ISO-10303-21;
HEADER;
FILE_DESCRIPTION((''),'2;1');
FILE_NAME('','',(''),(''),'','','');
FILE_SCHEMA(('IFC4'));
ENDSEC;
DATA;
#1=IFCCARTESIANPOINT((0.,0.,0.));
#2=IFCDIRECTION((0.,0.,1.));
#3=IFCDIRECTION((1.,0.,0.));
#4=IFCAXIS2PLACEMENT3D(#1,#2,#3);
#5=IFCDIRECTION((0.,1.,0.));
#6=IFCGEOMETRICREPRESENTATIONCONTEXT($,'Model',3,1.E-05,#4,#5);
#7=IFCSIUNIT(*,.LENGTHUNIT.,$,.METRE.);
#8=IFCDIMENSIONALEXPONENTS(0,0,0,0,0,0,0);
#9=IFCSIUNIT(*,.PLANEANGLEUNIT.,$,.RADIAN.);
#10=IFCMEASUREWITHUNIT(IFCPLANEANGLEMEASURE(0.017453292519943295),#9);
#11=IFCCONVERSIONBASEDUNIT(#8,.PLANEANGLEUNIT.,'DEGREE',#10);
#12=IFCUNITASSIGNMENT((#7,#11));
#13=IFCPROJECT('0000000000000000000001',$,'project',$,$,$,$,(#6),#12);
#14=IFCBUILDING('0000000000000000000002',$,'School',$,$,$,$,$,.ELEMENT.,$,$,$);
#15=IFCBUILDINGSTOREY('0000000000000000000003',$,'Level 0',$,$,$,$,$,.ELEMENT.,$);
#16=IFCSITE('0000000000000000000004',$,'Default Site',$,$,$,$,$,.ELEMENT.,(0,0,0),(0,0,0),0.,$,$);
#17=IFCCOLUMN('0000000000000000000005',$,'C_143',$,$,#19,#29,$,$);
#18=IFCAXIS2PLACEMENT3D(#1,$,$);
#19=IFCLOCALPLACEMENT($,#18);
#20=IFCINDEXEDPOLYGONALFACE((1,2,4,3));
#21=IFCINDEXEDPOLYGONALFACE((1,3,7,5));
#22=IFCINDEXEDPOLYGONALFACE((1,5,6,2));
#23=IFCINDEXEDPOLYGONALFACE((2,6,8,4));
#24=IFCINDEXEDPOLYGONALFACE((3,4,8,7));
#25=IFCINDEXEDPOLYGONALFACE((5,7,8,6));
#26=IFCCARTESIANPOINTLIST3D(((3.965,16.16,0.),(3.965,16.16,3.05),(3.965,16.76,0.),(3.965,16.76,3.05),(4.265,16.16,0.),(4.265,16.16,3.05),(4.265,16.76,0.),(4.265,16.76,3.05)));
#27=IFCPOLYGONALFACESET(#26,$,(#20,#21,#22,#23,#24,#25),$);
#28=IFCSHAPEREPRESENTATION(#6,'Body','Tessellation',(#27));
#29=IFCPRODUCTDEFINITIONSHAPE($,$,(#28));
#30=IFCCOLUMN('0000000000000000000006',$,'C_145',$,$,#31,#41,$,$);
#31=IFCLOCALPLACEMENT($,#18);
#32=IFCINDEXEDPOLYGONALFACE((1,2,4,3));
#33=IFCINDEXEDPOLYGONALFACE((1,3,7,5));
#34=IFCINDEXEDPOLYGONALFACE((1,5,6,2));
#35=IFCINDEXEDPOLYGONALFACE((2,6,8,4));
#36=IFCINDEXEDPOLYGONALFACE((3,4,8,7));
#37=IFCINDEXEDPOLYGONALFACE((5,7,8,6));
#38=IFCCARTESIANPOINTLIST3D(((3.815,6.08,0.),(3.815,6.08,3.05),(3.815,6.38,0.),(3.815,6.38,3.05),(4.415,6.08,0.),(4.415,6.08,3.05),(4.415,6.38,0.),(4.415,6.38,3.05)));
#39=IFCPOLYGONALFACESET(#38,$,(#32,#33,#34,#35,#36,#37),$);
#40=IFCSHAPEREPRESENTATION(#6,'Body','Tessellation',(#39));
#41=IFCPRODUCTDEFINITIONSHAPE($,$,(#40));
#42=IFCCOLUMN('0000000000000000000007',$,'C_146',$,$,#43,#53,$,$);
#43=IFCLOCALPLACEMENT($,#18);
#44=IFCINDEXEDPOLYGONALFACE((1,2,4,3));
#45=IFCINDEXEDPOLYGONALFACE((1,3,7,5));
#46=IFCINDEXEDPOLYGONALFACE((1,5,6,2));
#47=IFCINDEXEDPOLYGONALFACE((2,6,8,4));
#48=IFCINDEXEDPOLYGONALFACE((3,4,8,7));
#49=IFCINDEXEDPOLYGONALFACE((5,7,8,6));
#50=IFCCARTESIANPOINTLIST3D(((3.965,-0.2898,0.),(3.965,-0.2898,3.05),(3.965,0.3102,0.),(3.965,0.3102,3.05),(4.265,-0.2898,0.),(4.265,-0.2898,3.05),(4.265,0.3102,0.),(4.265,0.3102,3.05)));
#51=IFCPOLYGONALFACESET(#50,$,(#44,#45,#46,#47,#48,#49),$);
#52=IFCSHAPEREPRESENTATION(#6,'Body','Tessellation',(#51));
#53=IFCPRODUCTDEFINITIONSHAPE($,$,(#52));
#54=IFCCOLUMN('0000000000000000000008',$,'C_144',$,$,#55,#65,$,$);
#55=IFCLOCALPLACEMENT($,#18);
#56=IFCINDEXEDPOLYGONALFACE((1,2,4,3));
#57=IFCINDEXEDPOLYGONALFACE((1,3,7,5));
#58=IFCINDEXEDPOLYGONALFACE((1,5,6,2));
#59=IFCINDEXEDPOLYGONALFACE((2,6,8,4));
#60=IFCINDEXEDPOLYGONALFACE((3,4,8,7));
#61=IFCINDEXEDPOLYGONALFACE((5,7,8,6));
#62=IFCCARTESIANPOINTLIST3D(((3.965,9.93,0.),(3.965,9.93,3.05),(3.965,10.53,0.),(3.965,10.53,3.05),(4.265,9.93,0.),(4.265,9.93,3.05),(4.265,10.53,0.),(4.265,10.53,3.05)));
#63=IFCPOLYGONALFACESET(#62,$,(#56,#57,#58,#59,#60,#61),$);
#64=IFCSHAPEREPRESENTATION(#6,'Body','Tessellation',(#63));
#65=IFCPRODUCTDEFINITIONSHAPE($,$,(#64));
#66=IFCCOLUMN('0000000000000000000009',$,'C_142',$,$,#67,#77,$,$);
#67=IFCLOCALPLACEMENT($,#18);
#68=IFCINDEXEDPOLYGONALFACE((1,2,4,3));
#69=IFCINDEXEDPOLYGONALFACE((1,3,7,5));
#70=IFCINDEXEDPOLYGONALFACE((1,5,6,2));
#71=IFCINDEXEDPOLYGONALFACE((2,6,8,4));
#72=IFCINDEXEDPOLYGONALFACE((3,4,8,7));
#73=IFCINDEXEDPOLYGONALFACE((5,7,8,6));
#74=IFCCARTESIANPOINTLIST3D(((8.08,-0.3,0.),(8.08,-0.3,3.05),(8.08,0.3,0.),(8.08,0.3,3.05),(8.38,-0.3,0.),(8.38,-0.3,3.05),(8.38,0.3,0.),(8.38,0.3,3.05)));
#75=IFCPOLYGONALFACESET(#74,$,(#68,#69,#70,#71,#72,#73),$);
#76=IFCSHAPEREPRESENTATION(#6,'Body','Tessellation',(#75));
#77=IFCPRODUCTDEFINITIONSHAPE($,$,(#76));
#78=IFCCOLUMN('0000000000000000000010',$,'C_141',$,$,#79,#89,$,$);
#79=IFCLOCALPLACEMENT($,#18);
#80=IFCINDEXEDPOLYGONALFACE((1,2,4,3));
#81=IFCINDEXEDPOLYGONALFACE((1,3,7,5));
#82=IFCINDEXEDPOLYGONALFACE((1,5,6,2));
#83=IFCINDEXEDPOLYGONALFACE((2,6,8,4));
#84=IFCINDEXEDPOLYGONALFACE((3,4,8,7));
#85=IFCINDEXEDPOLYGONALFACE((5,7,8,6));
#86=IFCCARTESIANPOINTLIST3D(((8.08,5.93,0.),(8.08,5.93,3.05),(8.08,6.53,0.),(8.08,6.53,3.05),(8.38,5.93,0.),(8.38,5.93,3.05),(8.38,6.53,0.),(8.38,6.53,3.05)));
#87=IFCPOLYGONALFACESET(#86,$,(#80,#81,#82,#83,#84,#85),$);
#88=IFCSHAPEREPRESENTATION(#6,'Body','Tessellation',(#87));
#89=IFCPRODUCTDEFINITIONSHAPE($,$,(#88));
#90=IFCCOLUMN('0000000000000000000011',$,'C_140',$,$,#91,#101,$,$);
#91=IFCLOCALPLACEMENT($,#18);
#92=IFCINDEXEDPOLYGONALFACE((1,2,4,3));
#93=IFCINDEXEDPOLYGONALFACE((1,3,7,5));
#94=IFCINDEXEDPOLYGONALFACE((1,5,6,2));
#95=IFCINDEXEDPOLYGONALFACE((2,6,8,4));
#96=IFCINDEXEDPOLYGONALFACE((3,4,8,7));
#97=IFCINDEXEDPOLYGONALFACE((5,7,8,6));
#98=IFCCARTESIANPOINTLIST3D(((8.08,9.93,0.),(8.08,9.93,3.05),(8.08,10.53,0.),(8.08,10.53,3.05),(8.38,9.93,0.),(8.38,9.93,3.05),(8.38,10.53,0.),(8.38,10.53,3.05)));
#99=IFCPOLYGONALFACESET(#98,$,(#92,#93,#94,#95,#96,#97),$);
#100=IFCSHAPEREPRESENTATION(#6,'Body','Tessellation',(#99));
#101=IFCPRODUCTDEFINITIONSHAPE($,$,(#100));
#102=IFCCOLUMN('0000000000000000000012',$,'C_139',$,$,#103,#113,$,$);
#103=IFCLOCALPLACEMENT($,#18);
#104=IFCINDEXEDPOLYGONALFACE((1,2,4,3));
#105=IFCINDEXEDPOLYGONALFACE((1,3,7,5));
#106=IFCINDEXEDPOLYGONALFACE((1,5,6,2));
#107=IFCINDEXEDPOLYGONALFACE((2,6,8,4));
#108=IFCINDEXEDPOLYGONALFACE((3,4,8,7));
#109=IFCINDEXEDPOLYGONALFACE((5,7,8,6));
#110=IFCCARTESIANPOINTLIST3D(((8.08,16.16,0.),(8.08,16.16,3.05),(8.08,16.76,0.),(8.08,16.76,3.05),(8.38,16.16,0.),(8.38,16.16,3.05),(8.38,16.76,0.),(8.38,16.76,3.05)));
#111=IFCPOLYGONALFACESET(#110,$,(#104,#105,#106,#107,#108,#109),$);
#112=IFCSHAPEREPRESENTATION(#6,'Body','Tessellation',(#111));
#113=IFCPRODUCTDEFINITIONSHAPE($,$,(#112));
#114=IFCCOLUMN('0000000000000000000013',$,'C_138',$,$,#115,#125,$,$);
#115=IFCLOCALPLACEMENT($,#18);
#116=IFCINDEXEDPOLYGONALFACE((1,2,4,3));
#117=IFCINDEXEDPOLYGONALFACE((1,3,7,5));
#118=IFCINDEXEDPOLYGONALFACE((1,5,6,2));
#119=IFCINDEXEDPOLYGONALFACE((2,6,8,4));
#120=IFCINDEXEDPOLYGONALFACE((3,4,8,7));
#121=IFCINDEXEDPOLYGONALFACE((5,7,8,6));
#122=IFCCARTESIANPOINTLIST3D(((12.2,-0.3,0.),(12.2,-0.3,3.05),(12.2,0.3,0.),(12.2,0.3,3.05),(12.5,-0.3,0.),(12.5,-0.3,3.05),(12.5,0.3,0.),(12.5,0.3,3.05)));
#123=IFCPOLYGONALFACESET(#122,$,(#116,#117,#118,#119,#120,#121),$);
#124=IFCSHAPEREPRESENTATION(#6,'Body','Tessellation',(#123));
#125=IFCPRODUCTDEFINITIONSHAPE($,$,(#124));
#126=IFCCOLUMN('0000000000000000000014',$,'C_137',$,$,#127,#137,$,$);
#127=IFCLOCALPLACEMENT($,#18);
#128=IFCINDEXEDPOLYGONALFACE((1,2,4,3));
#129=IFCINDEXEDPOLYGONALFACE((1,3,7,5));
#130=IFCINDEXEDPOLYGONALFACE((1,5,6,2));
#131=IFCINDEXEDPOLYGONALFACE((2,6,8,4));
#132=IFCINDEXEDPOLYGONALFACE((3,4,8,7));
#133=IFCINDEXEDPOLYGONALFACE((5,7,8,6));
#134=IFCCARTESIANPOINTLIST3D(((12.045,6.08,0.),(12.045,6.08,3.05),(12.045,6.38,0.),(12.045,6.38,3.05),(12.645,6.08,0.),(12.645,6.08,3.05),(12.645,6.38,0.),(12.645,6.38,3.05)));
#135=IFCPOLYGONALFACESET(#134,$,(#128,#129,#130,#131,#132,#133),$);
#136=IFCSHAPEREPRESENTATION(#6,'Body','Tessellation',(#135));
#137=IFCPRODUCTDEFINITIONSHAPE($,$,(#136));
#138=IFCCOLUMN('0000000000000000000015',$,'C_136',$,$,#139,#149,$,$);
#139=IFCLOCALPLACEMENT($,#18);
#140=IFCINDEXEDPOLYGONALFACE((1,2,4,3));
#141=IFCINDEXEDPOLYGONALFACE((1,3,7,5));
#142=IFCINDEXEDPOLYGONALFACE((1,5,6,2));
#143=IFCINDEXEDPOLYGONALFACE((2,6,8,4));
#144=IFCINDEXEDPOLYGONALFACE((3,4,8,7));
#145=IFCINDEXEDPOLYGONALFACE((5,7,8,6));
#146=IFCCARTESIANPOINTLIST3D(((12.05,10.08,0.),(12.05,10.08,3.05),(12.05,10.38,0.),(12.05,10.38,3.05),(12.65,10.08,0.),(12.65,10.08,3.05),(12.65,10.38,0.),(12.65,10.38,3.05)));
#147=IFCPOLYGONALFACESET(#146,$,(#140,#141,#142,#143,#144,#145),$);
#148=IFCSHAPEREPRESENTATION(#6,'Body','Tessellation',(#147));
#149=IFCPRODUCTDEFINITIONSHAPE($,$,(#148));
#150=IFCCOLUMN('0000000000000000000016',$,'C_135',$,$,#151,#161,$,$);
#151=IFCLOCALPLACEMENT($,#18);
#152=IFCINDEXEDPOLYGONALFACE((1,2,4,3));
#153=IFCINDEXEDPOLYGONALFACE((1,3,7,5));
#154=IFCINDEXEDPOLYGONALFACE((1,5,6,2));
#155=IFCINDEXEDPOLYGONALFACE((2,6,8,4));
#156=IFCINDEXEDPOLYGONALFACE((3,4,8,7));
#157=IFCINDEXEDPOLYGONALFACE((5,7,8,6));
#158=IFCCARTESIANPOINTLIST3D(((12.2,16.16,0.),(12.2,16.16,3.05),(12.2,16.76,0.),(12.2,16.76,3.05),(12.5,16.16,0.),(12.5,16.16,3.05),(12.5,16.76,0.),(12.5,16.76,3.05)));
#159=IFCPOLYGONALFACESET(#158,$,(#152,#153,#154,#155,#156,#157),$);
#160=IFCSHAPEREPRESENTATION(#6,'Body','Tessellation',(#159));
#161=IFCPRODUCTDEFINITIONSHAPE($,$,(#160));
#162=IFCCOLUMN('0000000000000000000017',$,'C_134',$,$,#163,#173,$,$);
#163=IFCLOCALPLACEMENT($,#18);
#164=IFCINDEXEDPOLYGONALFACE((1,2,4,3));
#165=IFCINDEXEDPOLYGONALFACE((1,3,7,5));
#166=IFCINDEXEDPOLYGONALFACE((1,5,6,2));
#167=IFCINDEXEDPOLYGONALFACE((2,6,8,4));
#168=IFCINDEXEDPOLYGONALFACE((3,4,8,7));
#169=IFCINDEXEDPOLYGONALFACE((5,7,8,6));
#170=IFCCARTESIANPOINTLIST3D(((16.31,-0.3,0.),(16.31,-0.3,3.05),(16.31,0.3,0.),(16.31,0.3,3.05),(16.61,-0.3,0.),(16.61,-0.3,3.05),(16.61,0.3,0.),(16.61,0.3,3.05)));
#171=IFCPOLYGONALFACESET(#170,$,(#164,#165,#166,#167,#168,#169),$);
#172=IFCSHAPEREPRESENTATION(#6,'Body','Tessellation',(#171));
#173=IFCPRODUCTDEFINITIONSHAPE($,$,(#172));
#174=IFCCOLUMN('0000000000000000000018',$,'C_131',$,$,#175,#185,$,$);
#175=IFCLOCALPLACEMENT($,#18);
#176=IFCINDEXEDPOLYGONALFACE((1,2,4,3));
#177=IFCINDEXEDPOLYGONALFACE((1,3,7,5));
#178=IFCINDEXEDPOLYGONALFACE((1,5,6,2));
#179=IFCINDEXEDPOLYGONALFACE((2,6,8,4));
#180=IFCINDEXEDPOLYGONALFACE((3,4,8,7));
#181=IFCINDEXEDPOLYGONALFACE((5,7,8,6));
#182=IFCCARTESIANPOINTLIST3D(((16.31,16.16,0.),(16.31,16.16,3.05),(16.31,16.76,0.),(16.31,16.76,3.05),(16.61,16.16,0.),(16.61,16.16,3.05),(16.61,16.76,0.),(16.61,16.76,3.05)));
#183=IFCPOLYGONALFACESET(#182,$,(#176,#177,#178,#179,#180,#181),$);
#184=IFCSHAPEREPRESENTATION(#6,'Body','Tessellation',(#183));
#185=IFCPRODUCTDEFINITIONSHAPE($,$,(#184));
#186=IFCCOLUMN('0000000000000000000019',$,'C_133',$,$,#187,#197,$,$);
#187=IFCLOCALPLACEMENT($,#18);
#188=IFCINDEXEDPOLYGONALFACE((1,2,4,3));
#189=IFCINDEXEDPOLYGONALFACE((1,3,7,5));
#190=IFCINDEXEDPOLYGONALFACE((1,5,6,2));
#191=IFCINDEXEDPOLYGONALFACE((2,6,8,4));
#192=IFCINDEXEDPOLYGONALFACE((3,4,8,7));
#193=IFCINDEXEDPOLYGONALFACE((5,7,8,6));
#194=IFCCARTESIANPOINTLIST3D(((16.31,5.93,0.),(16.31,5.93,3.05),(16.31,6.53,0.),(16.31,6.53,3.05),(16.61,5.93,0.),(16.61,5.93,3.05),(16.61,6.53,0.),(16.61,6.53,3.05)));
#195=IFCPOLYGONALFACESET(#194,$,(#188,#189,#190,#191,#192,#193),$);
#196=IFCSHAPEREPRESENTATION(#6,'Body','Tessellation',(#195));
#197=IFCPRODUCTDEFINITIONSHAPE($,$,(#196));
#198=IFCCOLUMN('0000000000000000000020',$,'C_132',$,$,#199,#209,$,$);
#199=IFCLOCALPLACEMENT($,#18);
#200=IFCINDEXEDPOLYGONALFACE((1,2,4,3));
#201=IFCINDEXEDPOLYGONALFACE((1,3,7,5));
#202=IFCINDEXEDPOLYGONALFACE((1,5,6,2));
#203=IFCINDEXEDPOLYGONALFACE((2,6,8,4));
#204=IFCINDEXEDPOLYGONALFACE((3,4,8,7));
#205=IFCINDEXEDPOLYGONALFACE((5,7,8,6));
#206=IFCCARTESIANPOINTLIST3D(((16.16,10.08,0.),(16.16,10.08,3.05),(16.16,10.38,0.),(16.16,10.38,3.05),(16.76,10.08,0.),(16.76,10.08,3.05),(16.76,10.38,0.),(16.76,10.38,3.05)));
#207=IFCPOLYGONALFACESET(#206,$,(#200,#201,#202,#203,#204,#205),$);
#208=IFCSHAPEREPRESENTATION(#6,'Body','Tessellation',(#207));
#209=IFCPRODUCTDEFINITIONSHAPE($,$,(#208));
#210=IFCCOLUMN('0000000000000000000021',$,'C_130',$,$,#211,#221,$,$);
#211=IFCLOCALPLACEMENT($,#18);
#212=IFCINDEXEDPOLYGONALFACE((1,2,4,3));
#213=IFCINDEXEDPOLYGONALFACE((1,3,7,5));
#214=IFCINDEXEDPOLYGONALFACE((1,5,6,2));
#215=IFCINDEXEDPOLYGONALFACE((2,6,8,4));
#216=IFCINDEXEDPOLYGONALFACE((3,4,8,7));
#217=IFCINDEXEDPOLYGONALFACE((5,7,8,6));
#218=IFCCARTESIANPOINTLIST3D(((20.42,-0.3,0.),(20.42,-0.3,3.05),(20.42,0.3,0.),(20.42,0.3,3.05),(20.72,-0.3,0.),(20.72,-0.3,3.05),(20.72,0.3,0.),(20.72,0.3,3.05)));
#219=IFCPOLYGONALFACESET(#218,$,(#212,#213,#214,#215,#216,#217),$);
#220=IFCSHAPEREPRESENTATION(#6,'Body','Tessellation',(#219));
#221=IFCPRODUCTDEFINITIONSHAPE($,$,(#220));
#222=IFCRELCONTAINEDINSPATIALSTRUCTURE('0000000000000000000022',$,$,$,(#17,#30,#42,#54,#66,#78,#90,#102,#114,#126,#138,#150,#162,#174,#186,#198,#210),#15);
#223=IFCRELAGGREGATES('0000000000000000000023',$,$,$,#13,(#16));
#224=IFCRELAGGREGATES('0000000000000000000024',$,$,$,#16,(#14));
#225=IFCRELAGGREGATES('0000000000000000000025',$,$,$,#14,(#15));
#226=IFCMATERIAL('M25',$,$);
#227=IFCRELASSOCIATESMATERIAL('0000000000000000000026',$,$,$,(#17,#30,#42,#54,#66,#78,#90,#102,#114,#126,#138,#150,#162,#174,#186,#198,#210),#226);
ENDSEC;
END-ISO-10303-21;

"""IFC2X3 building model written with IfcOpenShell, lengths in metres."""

from ifc_helpers import new_model, entity, si_unit, converted_unit, direction, frame, frame_2d, origin_with_axes, place, context, project, spatial, rectangle, extrude, material, element, save


model = new_model("IFC2X3")

# Units and contexts
model_context = context("Model", 3, precision=1e-05, world=origin_with_axes(), true_north=direction((0.0, 1.0, 0.0)))
ifc_project = project(units=[si_unit("LENGTHUNIT", "METRE"), converted_unit("PLANEANGLEUNIT", "DEGREE", entity("IfcPlaneAngleMeasure", 0.017453292519943295), si_unit("PLANEANGLEUNIT", "RADIAN"), dimensions=[0, 0, 0, 0, 0, 0, 0])], contexts=[model_context])

# Site, building, storey
site = spatial("IfcSite", under=ifc_project, Name="Default Site", CompositionType="ELEMENT", RefLatitude=(0, 0, 0), RefLongitude=(0, 0, 0), RefElevation=0.0)
building = spatial("IfcBuilding", under=site, Name="School", CompositionType="ELEMENT")
storey = spatial("IfcBuildingStorey", under=building, Name="Level 0", CompositionType="ELEMENT")

# Columns
ifc_material = material(Name="M25")
placement = place(None, origin_with_axes())
element("IfcColumn", 1, at=placement, inside=storey, material=ifc_material, Name="C_143", context=model_context, shape_type="SweptSolid", body=[
    extrude(rectangle(XDim=0.3, YDim=0.6, at=frame_2d((0.0, 0.0), x_axis=(1.0, 0.0, 0.0))), frame((4.115, 16.46, 0.0), z_axis=(0.0, 0.0, 1.0), x_axis=(1.0, 0.0, 0.0)), (0.0, 0.0, 1.0), 3.05),
])
element("IfcColumn", 2, at=placement, inside=storey, material=ifc_material, Name="C_145", context=model_context, shape_type="SweptSolid", body=[
    extrude(rectangle(XDim=0.6, YDim=0.3, at=frame_2d((0.0, 0.0), x_axis=(1.0, 0.0, 0.0))), frame((4.115, 6.23, 0.0), z_axis=(0.0, 0.0, 1.0), x_axis=(1.0, 0.0, 0.0)), (0.0, 0.0, 1.0), 3.05),
])
element("IfcColumn", 3, at=placement, inside=storey, material=ifc_material, Name="C_146", context=model_context, shape_type="SweptSolid", body=[
    extrude(rectangle(XDim=0.3, YDim=0.6, at=frame_2d((0.0, 0.0), x_axis=(1.0, 0.0, 0.0))), frame((4.115, 0.0102, 0.0), z_axis=(0.0, 0.0, 1.0), x_axis=(1.0, 0.0, 0.0)), (0.0, 0.0, 1.0), 3.05),
])
element("IfcColumn", 4, at=placement, inside=storey, material=ifc_material, Name="C_144", context=model_context, shape_type="SweptSolid", body=[
    extrude(rectangle(XDim=0.3, YDim=0.6, at=frame_2d((0.0, 0.0), x_axis=(1.0, 0.0, 0.0))), frame((4.115, 10.23, 0.0), z_axis=(0.0, 0.0, 1.0), x_axis=(1.0, 0.0, 0.0)), (0.0, 0.0, 1.0), 3.05),
])
element("IfcColumn", 5, at=placement, inside=storey, material=ifc_material, Name="C_142", context=model_context, shape_type="SweptSolid", body=[
    extrude(rectangle(XDim=0.3, YDim=0.6, at=frame_2d((0.0, 0.0), x_axis=(1.0, 0.0, 0.0))), frame((8.23, 0.0, 0.0), z_axis=(0.0, 0.0, 1.0), x_axis=(1.0, 0.0, 0.0)), (0.0, 0.0, 1.0), 3.05),
])
element("IfcColumn", 6, at=placement, inside=storey, material=ifc_material, Name="C_141", context=model_context, shape_type="SweptSolid", body=[
    extrude(rectangle(XDim=0.3, YDim=0.6, at=frame_2d((0.0, 0.0), x_axis=(1.0, 0.0, 0.0))), frame((8.23, 6.23, 0.0), z_axis=(0.0, 0.0, 1.0), x_axis=(1.0, 0.0, 0.0)), (0.0, 0.0, 1.0), 3.05),
])
element("IfcColumn", 7, at=placement, inside=storey, material=ifc_material, Name="C_140", context=model_context, shape_type="SweptSolid", body=[
    extrude(rectangle(XDim=0.3, YDim=0.6, at=frame_2d((0.0, 0.0), x_axis=(1.0, 0.0, 0.0))), frame((8.23, 10.23, 0.0), z_axis=(0.0, 0.0, 1.0), x_axis=(1.0, 0.0, 0.0)), (0.0, 0.0, 1.0), 3.05),
])
element("IfcColumn", 8, at=placement, inside=storey, material=ifc_material, Name="C_139", context=model_context, shape_type="SweptSolid", body=[
    extrude(rectangle(XDim=0.3, YDim=0.6, at=frame_2d((0.0, 0.0), x_axis=(1.0, 0.0, 0.0))), frame((8.23, 16.46, 0.0), z_axis=(0.0, 0.0, 1.0), x_axis=(1.0, 0.0, 0.0)), (0.0, 0.0, 1.0), 3.05),
])
element("IfcColumn", 9, at=placement, inside=storey, material=ifc_material, Name="C_138", context=model_context, shape_type="SweptSolid", body=[
    extrude(rectangle(XDim=0.3, YDim=0.6, at=frame_2d((0.0, 0.0), x_axis=(1.0, 0.0, 0.0))), frame((12.35, 0.0, 0.0), z_axis=(0.0, 0.0, 1.0), x_axis=(1.0, 0.0, 0.0)), (0.0, 0.0, 1.0), 3.05),
])
element("IfcColumn", 10, at=placement, inside=storey, material=ifc_material, Name="C_137", context=model_context, shape_type="SweptSolid", body=[
    extrude(rectangle(XDim=0.6, YDim=0.3, at=frame_2d((0.0, 0.0), x_axis=(1.0, 0.0, 0.0))), frame((12.345, 6.23, 0.0), z_axis=(0.0, 0.0, 1.0), x_axis=(1.0, 0.0, 0.0)), (0.0, 0.0, 1.0), 3.05),
])
element("IfcColumn", 11, at=placement, inside=storey, material=ifc_material, Name="C_136", context=model_context, shape_type="SweptSolid", body=[
    extrude(rectangle(XDim=0.6, YDim=0.3, at=frame_2d((0.0, 0.0), x_axis=(1.0, 0.0, 0.0))), frame((12.35, 10.23, 0.0), z_axis=(0.0, 0.0, 1.0), x_axis=(1.0, 0.0, 0.0)), (0.0, 0.0, 1.0), 3.05),
])
element("IfcColumn", 12, at=placement, inside=storey, material=ifc_material, Name="C_135", context=model_context, shape_type="SweptSolid", body=[
    extrude(rectangle(XDim=0.3, YDim=0.6, at=frame_2d((0.0, 0.0), x_axis=(1.0, 0.0, 0.0))), frame((12.35, 16.46, 0.0), z_axis=(0.0, 0.0, 1.0), x_axis=(1.0, 0.0, 0.0)), (0.0, 0.0, 1.0), 3.05),
])
element("IfcColumn", 13, at=placement, inside=storey, material=ifc_material, Name="C_134", context=model_context, shape_type="SweptSolid", body=[
    extrude(rectangle(XDim=0.3, YDim=0.6, at=frame_2d((0.0, 0.0), x_axis=(1.0, 0.0, 0.0))), frame((16.46, 0.0, 0.0), z_axis=(0.0, 0.0, 1.0), x_axis=(1.0, 0.0, 0.0)), (0.0, 0.0, 1.0), 3.05),
])
element("IfcColumn", 14, at=placement, inside=storey, material=ifc_material, Name="C_131", context=model_context, shape_type="SweptSolid", body=[
    extrude(rectangle(XDim=0.3, YDim=0.6, at=frame_2d((0.0, 0.0), x_axis=(1.0, 0.0, 0.0))), frame((16.46, 16.46, 0.0), z_axis=(0.0, 0.0, 1.0), x_axis=(1.0, 0.0, 0.0)), (0.0, 0.0, 1.0), 3.05),
])
element("IfcColumn", 15, at=placement, inside=storey, material=ifc_material, Name="C_133", context=model_context, shape_type="SweptSolid", body=[
    extrude(rectangle(XDim=0.3, YDim=0.6, at=frame_2d((0.0, 0.0), x_axis=(1.0, 0.0, 0.0))), frame((16.46, 6.23, 0.0), z_axis=(0.0, 0.0, 1.0), x_axis=(1.0, 0.0, 0.0)), (0.0, 0.0, 1.0), 3.05),
])
element("IfcColumn", 16, at=placement, inside=storey, material=ifc_material, Name="C_132", context=model_context, shape_type="SweptSolid", body=[
    extrude(rectangle(XDim=0.6, YDim=0.3, at=frame_2d((0.0, 0.0), x_axis=(1.0, 0.0, 0.0))), frame((16.46, 10.23, 0.0), z_axis=(0.0, 0.0, 1.0), x_axis=(1.0, 0.0, 0.0)), (0.0, 0.0, 1.0), 3.05),
])
element("IfcColumn", 17, at=placement, inside=storey, material=ifc_material, Name="C_130", context=model_context, shape_type="SweptSolid", body=[
    extrude(rectangle(XDim=0.3, YDim=0.6, at=frame_2d((0.0, 0.0), x_axis=(1.0, 0.0, 0.0))), frame((20.57, 0.0, 0.0), z_axis=(0.0, 0.0, 1.0), x_axis=(1.0, 0.0, 0.0)), (0.0, 0.0, 1.0), 3.05),
])

save(model, "model.ifc")
